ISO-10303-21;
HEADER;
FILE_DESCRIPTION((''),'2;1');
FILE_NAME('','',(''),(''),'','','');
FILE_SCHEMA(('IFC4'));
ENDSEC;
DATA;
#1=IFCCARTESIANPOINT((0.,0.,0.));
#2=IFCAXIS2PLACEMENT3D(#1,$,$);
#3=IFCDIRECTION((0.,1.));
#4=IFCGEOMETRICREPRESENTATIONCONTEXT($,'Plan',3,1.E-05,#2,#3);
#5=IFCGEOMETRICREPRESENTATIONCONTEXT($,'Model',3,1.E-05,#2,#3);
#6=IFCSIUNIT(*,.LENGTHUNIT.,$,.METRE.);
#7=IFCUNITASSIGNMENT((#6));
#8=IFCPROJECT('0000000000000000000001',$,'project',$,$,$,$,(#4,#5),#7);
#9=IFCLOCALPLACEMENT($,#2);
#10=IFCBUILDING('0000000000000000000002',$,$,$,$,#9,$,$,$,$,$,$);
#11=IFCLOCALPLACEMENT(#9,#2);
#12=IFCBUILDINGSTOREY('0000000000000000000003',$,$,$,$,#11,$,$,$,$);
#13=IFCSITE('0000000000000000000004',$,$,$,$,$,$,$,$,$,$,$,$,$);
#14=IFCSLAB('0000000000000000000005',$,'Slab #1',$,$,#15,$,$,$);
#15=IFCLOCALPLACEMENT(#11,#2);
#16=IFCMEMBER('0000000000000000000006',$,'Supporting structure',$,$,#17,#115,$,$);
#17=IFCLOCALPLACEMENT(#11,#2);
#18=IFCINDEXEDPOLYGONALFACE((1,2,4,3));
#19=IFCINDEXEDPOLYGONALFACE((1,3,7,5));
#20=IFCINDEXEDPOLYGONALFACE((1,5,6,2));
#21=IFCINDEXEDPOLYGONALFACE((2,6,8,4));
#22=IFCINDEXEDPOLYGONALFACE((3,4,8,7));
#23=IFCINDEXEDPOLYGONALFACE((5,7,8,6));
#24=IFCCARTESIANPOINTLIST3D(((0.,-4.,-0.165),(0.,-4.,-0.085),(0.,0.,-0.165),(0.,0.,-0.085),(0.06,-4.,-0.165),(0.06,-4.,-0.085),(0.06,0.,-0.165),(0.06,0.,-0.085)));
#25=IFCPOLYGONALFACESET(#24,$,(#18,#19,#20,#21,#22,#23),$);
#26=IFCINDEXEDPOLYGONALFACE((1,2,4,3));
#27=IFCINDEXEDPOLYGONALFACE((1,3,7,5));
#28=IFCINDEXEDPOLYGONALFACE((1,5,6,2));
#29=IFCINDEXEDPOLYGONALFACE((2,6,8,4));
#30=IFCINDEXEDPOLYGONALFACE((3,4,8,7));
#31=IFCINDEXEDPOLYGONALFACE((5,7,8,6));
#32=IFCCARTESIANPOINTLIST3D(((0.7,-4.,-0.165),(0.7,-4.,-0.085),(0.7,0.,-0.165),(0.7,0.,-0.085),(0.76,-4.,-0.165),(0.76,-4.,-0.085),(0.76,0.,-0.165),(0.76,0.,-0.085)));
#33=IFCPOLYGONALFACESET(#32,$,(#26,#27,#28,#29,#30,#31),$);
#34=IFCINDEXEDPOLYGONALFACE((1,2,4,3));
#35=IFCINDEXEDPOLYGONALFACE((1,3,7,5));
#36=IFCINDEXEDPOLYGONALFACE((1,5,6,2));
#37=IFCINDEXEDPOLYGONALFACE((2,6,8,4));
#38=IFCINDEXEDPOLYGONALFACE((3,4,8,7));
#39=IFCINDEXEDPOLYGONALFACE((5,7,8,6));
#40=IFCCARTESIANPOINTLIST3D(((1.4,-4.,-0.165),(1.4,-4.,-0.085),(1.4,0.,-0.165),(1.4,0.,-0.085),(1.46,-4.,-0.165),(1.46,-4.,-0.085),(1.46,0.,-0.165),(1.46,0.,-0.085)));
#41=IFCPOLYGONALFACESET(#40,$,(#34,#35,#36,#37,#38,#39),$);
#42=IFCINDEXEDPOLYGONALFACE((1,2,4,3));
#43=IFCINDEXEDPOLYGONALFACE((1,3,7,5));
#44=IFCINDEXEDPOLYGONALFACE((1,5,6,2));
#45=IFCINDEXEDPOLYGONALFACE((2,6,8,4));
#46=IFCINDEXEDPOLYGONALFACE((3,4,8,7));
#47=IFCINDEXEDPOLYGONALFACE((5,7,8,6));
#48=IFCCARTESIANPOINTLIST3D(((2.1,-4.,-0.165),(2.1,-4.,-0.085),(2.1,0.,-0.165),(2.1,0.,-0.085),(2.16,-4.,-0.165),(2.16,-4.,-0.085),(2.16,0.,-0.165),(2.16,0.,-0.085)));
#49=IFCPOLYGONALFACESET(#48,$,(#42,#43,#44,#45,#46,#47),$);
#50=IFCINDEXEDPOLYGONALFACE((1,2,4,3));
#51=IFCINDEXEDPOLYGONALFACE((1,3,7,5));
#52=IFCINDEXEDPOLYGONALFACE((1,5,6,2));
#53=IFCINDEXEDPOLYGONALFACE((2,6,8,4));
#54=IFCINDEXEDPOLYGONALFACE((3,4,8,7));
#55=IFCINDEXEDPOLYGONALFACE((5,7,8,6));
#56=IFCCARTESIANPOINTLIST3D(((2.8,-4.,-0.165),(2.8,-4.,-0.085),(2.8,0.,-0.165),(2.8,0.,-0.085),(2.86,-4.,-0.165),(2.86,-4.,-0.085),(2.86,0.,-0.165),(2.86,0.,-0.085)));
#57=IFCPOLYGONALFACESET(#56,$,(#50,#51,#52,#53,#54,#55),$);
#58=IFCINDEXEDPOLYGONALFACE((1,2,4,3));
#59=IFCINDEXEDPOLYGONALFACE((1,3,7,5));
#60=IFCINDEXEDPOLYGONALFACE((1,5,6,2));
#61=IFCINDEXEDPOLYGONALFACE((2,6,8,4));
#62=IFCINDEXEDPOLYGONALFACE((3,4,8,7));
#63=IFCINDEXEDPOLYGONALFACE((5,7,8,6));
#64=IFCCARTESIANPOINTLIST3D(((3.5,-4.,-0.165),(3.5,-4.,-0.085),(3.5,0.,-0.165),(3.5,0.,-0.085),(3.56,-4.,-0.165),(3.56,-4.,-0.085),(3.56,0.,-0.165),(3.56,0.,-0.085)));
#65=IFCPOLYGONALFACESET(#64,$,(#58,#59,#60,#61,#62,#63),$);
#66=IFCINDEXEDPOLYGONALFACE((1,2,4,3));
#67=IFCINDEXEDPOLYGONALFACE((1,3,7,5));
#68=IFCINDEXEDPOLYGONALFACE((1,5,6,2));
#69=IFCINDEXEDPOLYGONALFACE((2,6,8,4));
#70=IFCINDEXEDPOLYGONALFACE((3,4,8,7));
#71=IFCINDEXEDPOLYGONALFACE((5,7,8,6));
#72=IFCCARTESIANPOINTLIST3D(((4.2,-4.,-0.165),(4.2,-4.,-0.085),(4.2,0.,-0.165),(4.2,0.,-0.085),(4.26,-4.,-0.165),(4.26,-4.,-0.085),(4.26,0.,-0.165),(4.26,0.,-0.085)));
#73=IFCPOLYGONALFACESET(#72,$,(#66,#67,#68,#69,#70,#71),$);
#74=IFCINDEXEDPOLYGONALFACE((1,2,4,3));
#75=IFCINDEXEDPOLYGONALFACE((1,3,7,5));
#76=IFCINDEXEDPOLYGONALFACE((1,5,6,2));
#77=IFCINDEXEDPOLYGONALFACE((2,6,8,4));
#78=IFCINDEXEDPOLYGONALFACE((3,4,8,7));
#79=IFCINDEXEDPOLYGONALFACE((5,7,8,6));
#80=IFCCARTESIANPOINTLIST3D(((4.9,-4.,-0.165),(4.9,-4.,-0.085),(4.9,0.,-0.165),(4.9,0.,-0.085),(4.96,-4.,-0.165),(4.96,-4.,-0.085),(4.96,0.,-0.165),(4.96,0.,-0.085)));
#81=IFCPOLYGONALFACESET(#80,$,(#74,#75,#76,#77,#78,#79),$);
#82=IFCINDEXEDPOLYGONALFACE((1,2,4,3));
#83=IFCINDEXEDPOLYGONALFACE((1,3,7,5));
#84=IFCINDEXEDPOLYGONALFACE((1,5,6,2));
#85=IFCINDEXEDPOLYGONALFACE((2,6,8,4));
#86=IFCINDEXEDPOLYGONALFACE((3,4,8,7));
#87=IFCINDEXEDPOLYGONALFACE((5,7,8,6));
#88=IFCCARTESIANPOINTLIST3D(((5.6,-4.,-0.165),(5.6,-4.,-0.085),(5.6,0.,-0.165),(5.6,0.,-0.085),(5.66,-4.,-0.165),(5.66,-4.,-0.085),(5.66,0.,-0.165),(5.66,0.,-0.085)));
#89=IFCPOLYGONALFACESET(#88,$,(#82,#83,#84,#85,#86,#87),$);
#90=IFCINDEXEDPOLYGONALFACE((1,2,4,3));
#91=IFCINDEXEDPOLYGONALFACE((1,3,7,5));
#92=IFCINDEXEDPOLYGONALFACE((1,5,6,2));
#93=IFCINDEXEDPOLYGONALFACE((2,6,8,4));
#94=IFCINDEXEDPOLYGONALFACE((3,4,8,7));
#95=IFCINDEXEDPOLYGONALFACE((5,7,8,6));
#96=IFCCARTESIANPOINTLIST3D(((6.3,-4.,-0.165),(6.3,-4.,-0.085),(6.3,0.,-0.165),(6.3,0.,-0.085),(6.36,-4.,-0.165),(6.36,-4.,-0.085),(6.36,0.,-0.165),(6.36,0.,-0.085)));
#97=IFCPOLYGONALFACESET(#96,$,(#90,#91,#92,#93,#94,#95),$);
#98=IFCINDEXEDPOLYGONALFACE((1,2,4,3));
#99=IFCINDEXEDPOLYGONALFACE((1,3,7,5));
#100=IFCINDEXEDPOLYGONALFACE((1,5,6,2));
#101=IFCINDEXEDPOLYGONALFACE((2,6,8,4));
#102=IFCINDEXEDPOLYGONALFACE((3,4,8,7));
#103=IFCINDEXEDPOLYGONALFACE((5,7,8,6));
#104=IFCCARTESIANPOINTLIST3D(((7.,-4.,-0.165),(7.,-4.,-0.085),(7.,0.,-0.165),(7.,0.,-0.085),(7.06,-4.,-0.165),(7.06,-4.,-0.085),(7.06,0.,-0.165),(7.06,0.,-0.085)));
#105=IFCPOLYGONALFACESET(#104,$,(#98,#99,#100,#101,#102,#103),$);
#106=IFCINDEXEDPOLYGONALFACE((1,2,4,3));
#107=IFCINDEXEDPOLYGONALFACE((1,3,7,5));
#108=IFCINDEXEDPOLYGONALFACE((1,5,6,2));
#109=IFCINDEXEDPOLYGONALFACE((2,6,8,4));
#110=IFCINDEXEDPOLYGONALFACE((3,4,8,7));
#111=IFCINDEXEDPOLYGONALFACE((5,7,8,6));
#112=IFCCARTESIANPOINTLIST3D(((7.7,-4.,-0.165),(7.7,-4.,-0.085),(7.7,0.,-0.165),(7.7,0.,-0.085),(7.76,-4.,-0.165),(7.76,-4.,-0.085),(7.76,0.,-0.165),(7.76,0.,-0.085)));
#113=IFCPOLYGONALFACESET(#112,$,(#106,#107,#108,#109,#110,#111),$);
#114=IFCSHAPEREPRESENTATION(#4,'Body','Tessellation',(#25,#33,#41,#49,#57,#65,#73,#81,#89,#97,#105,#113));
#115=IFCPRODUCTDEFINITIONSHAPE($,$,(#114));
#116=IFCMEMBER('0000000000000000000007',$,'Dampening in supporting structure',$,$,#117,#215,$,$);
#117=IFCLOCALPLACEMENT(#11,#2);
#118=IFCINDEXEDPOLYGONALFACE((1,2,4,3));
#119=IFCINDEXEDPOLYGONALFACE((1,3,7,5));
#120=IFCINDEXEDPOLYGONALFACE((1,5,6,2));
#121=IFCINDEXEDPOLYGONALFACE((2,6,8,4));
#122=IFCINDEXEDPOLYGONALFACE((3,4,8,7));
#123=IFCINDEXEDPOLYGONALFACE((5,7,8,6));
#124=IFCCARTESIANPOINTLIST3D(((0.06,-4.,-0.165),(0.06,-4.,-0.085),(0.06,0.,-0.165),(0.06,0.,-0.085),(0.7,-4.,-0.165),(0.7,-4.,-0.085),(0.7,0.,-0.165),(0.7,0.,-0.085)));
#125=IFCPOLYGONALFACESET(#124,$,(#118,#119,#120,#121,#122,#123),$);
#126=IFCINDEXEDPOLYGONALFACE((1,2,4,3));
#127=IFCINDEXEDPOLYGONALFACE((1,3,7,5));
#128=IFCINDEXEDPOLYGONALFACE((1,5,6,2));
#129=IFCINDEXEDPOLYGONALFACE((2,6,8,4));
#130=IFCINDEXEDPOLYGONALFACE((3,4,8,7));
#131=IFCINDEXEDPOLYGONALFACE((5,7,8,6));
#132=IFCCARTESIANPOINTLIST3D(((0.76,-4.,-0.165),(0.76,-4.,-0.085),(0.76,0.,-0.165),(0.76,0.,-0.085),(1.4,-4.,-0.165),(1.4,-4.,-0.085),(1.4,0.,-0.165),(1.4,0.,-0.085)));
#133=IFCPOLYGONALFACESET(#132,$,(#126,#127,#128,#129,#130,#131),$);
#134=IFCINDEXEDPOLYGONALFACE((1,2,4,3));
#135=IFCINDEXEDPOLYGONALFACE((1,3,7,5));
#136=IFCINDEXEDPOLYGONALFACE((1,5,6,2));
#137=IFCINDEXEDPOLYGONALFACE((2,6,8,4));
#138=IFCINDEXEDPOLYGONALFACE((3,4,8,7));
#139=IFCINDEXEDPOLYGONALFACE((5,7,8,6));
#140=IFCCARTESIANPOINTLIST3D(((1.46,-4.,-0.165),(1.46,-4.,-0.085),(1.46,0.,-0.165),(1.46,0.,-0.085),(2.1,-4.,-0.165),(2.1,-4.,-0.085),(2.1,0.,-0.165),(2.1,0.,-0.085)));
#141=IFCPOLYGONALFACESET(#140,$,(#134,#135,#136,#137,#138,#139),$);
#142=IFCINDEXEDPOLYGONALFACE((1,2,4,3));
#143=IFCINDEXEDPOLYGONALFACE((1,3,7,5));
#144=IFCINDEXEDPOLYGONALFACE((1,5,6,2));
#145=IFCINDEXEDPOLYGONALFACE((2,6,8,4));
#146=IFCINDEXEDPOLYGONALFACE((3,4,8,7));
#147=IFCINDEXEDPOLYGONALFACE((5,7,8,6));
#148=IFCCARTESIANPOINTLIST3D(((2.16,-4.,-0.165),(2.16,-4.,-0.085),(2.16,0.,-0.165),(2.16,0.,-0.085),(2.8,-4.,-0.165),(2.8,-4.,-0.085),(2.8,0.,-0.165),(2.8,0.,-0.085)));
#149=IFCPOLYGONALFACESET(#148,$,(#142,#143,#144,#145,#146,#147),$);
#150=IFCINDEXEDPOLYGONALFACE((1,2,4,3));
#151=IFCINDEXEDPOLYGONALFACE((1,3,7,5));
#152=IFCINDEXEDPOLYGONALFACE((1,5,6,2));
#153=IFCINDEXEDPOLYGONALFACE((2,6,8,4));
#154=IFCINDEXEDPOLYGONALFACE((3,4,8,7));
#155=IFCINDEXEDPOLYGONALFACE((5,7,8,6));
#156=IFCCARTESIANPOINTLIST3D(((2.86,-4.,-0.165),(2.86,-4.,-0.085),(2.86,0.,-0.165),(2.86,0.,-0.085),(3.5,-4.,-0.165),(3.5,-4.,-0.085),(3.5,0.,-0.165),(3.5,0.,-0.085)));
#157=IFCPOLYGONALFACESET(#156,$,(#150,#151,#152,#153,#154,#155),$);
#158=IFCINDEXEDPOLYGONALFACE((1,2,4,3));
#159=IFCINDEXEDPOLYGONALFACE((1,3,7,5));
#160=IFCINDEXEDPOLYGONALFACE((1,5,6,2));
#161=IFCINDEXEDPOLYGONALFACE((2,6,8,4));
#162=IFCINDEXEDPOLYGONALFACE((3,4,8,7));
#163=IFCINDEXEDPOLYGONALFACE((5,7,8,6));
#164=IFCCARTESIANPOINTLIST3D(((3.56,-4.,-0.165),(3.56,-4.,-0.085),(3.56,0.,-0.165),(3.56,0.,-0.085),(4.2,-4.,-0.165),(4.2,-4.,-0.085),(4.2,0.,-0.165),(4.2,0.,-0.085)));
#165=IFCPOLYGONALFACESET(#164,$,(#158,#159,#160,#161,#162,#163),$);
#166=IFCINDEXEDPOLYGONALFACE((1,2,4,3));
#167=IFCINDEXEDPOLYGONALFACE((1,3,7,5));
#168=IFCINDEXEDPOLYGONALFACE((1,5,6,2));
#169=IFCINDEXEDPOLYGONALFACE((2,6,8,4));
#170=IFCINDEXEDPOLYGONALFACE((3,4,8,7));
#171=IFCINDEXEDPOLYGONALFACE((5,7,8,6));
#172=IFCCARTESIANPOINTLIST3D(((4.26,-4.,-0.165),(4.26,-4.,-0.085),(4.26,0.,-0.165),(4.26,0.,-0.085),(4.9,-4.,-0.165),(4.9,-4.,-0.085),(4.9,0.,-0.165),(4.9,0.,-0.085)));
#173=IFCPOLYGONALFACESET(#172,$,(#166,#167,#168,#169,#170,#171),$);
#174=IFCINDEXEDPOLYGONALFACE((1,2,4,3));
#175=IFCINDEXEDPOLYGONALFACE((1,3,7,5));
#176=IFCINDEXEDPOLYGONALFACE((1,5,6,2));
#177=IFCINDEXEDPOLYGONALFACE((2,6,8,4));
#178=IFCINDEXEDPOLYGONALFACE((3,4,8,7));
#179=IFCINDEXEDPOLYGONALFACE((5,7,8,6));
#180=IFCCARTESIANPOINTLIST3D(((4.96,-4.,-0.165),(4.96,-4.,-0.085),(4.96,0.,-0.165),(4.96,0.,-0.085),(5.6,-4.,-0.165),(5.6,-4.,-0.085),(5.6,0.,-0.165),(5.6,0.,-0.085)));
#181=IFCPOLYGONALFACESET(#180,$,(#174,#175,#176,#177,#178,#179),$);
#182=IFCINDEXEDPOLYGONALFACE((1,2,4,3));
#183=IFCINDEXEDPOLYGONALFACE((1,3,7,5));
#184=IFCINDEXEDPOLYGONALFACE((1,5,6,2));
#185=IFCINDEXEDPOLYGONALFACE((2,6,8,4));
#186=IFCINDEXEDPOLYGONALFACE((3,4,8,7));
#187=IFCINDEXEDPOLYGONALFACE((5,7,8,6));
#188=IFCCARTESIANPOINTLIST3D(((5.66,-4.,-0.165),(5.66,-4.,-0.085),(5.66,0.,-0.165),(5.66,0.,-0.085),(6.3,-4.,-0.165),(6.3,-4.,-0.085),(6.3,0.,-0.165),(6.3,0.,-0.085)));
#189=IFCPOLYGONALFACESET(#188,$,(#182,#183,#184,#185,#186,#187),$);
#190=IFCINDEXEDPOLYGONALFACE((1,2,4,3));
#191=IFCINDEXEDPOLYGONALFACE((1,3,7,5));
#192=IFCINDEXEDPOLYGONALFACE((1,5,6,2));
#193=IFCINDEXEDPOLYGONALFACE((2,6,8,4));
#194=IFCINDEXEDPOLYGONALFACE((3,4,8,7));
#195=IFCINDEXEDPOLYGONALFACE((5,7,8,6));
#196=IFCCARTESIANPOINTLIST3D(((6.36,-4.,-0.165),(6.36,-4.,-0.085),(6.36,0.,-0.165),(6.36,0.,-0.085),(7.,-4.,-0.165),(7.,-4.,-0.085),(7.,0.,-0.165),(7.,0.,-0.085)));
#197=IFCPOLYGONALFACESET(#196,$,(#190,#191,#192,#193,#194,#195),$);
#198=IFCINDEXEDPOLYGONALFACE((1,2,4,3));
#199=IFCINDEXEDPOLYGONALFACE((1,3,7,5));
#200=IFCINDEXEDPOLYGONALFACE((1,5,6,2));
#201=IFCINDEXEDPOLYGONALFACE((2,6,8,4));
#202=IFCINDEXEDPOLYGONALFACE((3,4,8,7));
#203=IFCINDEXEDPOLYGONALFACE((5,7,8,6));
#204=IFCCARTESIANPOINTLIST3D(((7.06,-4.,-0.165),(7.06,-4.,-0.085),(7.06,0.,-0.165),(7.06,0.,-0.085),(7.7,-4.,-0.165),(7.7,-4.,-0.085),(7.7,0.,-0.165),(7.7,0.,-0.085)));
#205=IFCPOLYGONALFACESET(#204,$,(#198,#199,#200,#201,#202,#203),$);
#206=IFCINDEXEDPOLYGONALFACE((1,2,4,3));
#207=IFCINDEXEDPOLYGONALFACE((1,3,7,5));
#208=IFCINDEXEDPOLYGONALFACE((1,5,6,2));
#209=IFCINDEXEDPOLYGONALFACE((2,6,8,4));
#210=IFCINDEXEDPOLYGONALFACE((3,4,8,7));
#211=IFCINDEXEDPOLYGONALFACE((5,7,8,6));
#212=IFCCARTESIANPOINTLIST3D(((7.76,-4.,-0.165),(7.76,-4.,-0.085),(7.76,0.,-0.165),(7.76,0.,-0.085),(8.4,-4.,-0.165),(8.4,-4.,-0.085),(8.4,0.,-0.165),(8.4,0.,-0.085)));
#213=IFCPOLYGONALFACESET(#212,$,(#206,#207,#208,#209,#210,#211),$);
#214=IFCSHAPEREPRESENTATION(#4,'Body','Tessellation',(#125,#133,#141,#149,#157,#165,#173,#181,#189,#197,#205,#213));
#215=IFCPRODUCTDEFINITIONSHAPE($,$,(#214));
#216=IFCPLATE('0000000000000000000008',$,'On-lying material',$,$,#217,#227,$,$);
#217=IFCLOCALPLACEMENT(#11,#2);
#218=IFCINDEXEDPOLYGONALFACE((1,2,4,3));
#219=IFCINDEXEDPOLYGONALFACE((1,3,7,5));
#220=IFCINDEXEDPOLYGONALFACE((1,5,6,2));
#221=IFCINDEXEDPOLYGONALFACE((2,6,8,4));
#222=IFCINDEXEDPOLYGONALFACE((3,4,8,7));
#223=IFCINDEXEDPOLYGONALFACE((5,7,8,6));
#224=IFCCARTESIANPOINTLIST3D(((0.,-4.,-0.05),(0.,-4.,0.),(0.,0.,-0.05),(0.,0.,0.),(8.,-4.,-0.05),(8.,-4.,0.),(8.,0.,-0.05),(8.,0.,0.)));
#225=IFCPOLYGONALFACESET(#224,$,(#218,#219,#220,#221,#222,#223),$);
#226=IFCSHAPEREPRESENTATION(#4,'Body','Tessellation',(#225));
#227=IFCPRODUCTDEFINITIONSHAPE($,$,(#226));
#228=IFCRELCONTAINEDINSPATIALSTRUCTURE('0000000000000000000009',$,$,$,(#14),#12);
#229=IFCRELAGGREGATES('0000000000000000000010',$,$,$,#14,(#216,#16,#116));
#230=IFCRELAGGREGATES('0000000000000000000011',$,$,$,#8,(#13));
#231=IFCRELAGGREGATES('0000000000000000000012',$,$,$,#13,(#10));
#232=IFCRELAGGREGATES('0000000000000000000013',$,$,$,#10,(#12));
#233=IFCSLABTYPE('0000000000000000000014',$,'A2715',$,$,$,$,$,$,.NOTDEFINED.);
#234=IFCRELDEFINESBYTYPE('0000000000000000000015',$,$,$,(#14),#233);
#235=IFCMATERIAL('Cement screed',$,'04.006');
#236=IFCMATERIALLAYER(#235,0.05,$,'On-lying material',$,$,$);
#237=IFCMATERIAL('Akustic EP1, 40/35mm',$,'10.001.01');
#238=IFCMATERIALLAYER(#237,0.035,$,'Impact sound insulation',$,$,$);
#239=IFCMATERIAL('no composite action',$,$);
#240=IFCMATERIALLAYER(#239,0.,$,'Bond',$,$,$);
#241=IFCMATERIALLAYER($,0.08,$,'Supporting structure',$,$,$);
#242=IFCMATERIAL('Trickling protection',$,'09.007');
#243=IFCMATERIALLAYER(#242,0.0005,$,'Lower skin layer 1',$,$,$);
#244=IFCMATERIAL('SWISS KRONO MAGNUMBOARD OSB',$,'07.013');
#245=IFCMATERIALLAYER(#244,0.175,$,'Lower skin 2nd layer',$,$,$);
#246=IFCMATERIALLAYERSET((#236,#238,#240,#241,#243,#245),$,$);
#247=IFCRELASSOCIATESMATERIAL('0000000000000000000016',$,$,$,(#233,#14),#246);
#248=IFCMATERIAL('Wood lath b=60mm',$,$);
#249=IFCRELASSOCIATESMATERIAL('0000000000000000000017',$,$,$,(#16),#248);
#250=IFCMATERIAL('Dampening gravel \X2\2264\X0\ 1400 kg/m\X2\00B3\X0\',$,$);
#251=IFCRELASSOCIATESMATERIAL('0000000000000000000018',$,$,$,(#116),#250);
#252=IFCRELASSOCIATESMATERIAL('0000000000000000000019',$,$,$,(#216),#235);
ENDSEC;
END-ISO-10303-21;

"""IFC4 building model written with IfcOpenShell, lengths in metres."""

from ifc_helpers import new_model, si_unit, direction, frame, frame_2d, origin, origin_with_axes, place, context, project, spatial, rectangle, extrude, material, layer, layer_set, type_object, element, aggregate, save


model = new_model("IFC4")

# Units and contexts
plan_context = context("Plan", 3, precision=1e-05, world=origin(), true_north=direction((0.0, 1.0)))
model_context = context("Model", 3, precision=1e-05, world=origin(), true_north=direction((0.0, 1.0)))
ifc_project = project(units=[si_unit("LENGTHUNIT", "METRE")], contexts=[plan_context, model_context])

# Site, building, storey
site = spatial("IfcSite", under=ifc_project)
building_placement = place(None, origin())
building = spatial("IfcBuilding", under=site, at=building_placement)
storey_placement = place(building_placement, origin())
storey = spatial("IfcBuildingStorey", under=building, at=storey_placement)

# Slab, members, plate
ifc_material_1 = material(Name="Cement screed", Category="04.006")
ifc_layer_1 = layer(ifc_material_1, 0.05, Name="On-lying material")
ifc_material_2 = material(Name="Akustic EP1, 40/35mm", Category="10.001.01")
ifc_layer_2 = layer(ifc_material_2, 0.035, Name="Impact sound insulation")
ifc_material_3 = material(Name="no composite action")
ifc_layer_3 = layer(ifc_material_3, 0.0, Name="Bond")
ifc_layer_4 = layer(None, 0.08, Name="Supporting structure")
ifc_material_4 = material(Name="Trickling protection", Category="09.007")
ifc_layer_5 = layer(ifc_material_4, 0.0005, Name="Lower skin layer 1")
ifc_material_5 = material(Name="SWISS KRONO MAGNUMBOARD OSB", Category="07.013")
ifc_layer_6 = layer(ifc_material_5, 0.175, Name="Lower skin 2nd layer")
ifc_layer_set = layer_set([ifc_layer_1, ifc_layer_2, ifc_layer_3, ifc_layer_4, ifc_layer_5, ifc_layer_6])
slab_type = type_object("IfcSlabType", Name="A2715", PredefinedType="NOTDEFINED", material=ifc_layer_set)
slab_placement = place(None, frame((0.0, 0.0, 0.0), z_axis=(0.0, 0.0, -1.0), x_axis=(1.0, 0.0, 0.0)))
slab = element("IfcSlab", 1, at=slab_placement, inside=storey, type_object=slab_type, material=ifc_layer_set, Name="Slab #1")
ifc_material_6 = material(Name="Wood lath b=60mm")
member_1_placement = place(slab_placement, origin())
member_1 = element("IfcMember", 2, at=member_1_placement, material=ifc_material_6, Name="Supporting structure", context=plan_context, shape_type="SweptSolid", body=[
    extrude(rectangle(XDim=0.06, YDim=0.08, at=frame_2d((0.03, 0.04), x_axis=(1.0, 0.0))), frame((0.0, 4.0, 0.085), z_axis=(0.0, -1.0, 0.0), x_axis=(1.0, 0.0, 0.0)), (0.0, 0.0, 1.0), 4.0),
    extrude(rectangle(XDim=0.06, YDim=0.08, at=frame_2d((0.03, 0.04), x_axis=(1.0, 0.0))), frame((0.7, 4.0, 0.085), z_axis=(0.0, -1.0, 0.0), x_axis=(1.0, 0.0, 0.0)), (0.0, 0.0, 1.0), 4.0),
    extrude(rectangle(XDim=0.06, YDim=0.08, at=frame_2d((0.03, 0.04), x_axis=(1.0, 0.0))), frame((1.4, 4.0, 0.085), z_axis=(0.0, -1.0, 0.0), x_axis=(1.0, 0.0, 0.0)), (0.0, 0.0, 1.0), 4.0),
    extrude(rectangle(XDim=0.06, YDim=0.08, at=frame_2d((0.03, 0.04), x_axis=(1.0, 0.0))), frame((2.1, 4.0, 0.085), z_axis=(0.0, -1.0, 0.0), x_axis=(1.0, 0.0, 0.0)), (0.0, 0.0, 1.0), 4.0),
    extrude(rectangle(XDim=0.06, YDim=0.08, at=frame_2d((0.03, 0.04), x_axis=(1.0, 0.0))), frame((2.8, 4.0, 0.085), z_axis=(0.0, -1.0, 0.0), x_axis=(1.0, 0.0, 0.0)), (0.0, 0.0, 1.0), 4.0),
    extrude(rectangle(XDim=0.06, YDim=0.08, at=frame_2d((0.03, 0.04), x_axis=(1.0, 0.0))), frame((3.5, 4.0, 0.085), z_axis=(0.0, -1.0, 0.0), x_axis=(1.0, 0.0, 0.0)), (0.0, 0.0, 1.0), 4.0),
    extrude(rectangle(XDim=0.06, YDim=0.08, at=frame_2d((0.03, 0.04), x_axis=(1.0, 0.0))), frame((4.2, 4.0, 0.085), z_axis=(0.0, -1.0, 0.0), x_axis=(1.0, 0.0, 0.0)), (0.0, 0.0, 1.0), 4.0),
    extrude(rectangle(XDim=0.06, YDim=0.08, at=frame_2d((0.03, 0.04), x_axis=(1.0, 0.0))), frame((4.9, 4.0, 0.085), z_axis=(0.0, -1.0, 0.0), x_axis=(1.0, 0.0, 0.0)), (0.0, 0.0, 1.0), 4.0),
    extrude(rectangle(XDim=0.06, YDim=0.08, at=frame_2d((0.03, 0.04), x_axis=(1.0, 0.0))), frame((5.6, 4.0, 0.085), z_axis=(0.0, -1.0, 0.0), x_axis=(1.0, 0.0, 0.0)), (0.0, 0.0, 1.0), 4.0),
    extrude(rectangle(XDim=0.06, YDim=0.08, at=frame_2d((0.03, 0.04), x_axis=(1.0, 0.0))), frame((6.3, 4.0, 0.085), z_axis=(0.0, -1.0, 0.0), x_axis=(1.0, 0.0, 0.0)), (0.0, 0.0, 1.0), 4.0),
    extrude(rectangle(XDim=0.06, YDim=0.08, at=frame_2d((0.03, 0.04), x_axis=(1.0, 0.0))), frame((7.0, 4.0, 0.085), z_axis=(0.0, -1.0, 0.0), x_axis=(1.0, 0.0, 0.0)), (0.0, 0.0, 1.0), 4.0),
    extrude(rectangle(XDim=0.06, YDim=0.08, at=frame_2d((0.03, 0.04), x_axis=(1.0, 0.0))), frame((7.7, 4.0, 0.085), z_axis=(0.0, -1.0, 0.0), x_axis=(1.0, 0.0, 0.0)), (0.0, 0.0, 1.0), 4.0),
])
ifc_material_7 = material(Name="Dampening gravel ≤ 1400 kg/m³")
member_2_placement = place(slab_placement, origin())
member_2 = element("IfcMember", 3, at=member_2_placement, material=ifc_material_7, Name="Dampening in supporting structure", context=plan_context, shape_type="SweptSolid", body=[
    extrude(rectangle(XDim=0.64, YDim=0.08, at=frame_2d((0.32, 0.04), x_axis=(1.0, 0.0))), frame((0.06, 4.0, 0.085), z_axis=(0.0, -1.0, 0.0), x_axis=(1.0, 0.0, 0.0)), (0.0, 0.0, 1.0), 4.0),
    extrude(rectangle(XDim=0.64, YDim=0.08, at=frame_2d((0.32, 0.04), x_axis=(1.0, 0.0))), frame((0.76, 4.0, 0.085), z_axis=(0.0, -1.0, 0.0), x_axis=(1.0, 0.0, 0.0)), (0.0, 0.0, 1.0), 4.0),
    extrude(rectangle(XDim=0.64, YDim=0.08, at=frame_2d((0.32, 0.04), x_axis=(1.0, 0.0))), frame((1.46, 4.0, 0.085), z_axis=(0.0, -1.0, 0.0), x_axis=(1.0, 0.0, 0.0)), (0.0, 0.0, 1.0), 4.0),
    extrude(rectangle(XDim=0.64, YDim=0.08, at=frame_2d((0.32, 0.04), x_axis=(1.0, 0.0))), frame((2.16, 4.0, 0.085), z_axis=(0.0, -1.0, 0.0), x_axis=(1.0, 0.0, 0.0)), (0.0, 0.0, 1.0), 4.0),
    extrude(rectangle(XDim=0.64, YDim=0.08, at=frame_2d((0.32, 0.04), x_axis=(1.0, 0.0))), frame((2.86, 4.0, 0.085), z_axis=(0.0, -1.0, 0.0), x_axis=(1.0, 0.0, 0.0)), (0.0, 0.0, 1.0), 4.0),
    extrude(rectangle(XDim=0.64, YDim=0.08, at=frame_2d((0.32, 0.04), x_axis=(1.0, 0.0))), frame((3.56, 4.0, 0.085), z_axis=(0.0, -1.0, 0.0), x_axis=(1.0, 0.0, 0.0)), (0.0, 0.0, 1.0), 4.0),
    extrude(rectangle(XDim=0.64, YDim=0.08, at=frame_2d((0.32, 0.04), x_axis=(1.0, 0.0))), frame((4.26, 4.0, 0.085), z_axis=(0.0, -1.0, 0.0), x_axis=(1.0, 0.0, 0.0)), (0.0, 0.0, 1.0), 4.0),
    extrude(rectangle(XDim=0.64, YDim=0.08, at=frame_2d((0.32, 0.04), x_axis=(1.0, 0.0))), frame((4.96, 4.0, 0.085), z_axis=(0.0, -1.0, 0.0), x_axis=(1.0, 0.0, 0.0)), (0.0, 0.0, 1.0), 4.0),
    extrude(rectangle(XDim=0.64, YDim=0.08, at=frame_2d((0.32, 0.04), x_axis=(1.0, 0.0))), frame((5.66, 4.0, 0.085), z_axis=(0.0, -1.0, 0.0), x_axis=(1.0, 0.0, 0.0)), (0.0, 0.0, 1.0), 4.0),
    extrude(rectangle(XDim=0.64, YDim=0.08, at=frame_2d((0.32, 0.04), x_axis=(1.0, 0.0))), frame((6.36, 4.0, 0.085), z_axis=(0.0, -1.0, 0.0), x_axis=(1.0, 0.0, 0.0)), (0.0, 0.0, 1.0), 4.0),
    extrude(rectangle(XDim=0.64, YDim=0.08, at=frame_2d((0.32, 0.04), x_axis=(1.0, 0.0))), frame((7.06, 4.0, 0.085), z_axis=(0.0, -1.0, 0.0), x_axis=(1.0, 0.0, 0.0)), (0.0, 0.0, 1.0), 4.0),
    extrude(rectangle(XDim=0.64, YDim=0.08, at=frame_2d((0.32, 0.04), x_axis=(1.0, 0.0))), frame((7.76, 4.0, 0.085), z_axis=(0.0, -1.0, 0.0), x_axis=(1.0, 0.0, 0.0)), (0.0, 0.0, 1.0), 4.0),
])
plate_1_placement = place(slab_placement, origin())
plate_1 = element("IfcPlate", 4, at=plate_1_placement, material=ifc_material_1, Name="On-lying material", context=plan_context, shape_type="SweptSolid", body=[
    extrude(rectangle(XDim=8.0, YDim=4.0, at=frame_2d((4.0, 2.0), x_axis=(1.0, 0.0))), origin_with_axes(), (0.0, 0.0, 1.0), 0.05),
])
aggregate(slab, [plate_1, member_1, member_2])

save(model, "model.ifc")
